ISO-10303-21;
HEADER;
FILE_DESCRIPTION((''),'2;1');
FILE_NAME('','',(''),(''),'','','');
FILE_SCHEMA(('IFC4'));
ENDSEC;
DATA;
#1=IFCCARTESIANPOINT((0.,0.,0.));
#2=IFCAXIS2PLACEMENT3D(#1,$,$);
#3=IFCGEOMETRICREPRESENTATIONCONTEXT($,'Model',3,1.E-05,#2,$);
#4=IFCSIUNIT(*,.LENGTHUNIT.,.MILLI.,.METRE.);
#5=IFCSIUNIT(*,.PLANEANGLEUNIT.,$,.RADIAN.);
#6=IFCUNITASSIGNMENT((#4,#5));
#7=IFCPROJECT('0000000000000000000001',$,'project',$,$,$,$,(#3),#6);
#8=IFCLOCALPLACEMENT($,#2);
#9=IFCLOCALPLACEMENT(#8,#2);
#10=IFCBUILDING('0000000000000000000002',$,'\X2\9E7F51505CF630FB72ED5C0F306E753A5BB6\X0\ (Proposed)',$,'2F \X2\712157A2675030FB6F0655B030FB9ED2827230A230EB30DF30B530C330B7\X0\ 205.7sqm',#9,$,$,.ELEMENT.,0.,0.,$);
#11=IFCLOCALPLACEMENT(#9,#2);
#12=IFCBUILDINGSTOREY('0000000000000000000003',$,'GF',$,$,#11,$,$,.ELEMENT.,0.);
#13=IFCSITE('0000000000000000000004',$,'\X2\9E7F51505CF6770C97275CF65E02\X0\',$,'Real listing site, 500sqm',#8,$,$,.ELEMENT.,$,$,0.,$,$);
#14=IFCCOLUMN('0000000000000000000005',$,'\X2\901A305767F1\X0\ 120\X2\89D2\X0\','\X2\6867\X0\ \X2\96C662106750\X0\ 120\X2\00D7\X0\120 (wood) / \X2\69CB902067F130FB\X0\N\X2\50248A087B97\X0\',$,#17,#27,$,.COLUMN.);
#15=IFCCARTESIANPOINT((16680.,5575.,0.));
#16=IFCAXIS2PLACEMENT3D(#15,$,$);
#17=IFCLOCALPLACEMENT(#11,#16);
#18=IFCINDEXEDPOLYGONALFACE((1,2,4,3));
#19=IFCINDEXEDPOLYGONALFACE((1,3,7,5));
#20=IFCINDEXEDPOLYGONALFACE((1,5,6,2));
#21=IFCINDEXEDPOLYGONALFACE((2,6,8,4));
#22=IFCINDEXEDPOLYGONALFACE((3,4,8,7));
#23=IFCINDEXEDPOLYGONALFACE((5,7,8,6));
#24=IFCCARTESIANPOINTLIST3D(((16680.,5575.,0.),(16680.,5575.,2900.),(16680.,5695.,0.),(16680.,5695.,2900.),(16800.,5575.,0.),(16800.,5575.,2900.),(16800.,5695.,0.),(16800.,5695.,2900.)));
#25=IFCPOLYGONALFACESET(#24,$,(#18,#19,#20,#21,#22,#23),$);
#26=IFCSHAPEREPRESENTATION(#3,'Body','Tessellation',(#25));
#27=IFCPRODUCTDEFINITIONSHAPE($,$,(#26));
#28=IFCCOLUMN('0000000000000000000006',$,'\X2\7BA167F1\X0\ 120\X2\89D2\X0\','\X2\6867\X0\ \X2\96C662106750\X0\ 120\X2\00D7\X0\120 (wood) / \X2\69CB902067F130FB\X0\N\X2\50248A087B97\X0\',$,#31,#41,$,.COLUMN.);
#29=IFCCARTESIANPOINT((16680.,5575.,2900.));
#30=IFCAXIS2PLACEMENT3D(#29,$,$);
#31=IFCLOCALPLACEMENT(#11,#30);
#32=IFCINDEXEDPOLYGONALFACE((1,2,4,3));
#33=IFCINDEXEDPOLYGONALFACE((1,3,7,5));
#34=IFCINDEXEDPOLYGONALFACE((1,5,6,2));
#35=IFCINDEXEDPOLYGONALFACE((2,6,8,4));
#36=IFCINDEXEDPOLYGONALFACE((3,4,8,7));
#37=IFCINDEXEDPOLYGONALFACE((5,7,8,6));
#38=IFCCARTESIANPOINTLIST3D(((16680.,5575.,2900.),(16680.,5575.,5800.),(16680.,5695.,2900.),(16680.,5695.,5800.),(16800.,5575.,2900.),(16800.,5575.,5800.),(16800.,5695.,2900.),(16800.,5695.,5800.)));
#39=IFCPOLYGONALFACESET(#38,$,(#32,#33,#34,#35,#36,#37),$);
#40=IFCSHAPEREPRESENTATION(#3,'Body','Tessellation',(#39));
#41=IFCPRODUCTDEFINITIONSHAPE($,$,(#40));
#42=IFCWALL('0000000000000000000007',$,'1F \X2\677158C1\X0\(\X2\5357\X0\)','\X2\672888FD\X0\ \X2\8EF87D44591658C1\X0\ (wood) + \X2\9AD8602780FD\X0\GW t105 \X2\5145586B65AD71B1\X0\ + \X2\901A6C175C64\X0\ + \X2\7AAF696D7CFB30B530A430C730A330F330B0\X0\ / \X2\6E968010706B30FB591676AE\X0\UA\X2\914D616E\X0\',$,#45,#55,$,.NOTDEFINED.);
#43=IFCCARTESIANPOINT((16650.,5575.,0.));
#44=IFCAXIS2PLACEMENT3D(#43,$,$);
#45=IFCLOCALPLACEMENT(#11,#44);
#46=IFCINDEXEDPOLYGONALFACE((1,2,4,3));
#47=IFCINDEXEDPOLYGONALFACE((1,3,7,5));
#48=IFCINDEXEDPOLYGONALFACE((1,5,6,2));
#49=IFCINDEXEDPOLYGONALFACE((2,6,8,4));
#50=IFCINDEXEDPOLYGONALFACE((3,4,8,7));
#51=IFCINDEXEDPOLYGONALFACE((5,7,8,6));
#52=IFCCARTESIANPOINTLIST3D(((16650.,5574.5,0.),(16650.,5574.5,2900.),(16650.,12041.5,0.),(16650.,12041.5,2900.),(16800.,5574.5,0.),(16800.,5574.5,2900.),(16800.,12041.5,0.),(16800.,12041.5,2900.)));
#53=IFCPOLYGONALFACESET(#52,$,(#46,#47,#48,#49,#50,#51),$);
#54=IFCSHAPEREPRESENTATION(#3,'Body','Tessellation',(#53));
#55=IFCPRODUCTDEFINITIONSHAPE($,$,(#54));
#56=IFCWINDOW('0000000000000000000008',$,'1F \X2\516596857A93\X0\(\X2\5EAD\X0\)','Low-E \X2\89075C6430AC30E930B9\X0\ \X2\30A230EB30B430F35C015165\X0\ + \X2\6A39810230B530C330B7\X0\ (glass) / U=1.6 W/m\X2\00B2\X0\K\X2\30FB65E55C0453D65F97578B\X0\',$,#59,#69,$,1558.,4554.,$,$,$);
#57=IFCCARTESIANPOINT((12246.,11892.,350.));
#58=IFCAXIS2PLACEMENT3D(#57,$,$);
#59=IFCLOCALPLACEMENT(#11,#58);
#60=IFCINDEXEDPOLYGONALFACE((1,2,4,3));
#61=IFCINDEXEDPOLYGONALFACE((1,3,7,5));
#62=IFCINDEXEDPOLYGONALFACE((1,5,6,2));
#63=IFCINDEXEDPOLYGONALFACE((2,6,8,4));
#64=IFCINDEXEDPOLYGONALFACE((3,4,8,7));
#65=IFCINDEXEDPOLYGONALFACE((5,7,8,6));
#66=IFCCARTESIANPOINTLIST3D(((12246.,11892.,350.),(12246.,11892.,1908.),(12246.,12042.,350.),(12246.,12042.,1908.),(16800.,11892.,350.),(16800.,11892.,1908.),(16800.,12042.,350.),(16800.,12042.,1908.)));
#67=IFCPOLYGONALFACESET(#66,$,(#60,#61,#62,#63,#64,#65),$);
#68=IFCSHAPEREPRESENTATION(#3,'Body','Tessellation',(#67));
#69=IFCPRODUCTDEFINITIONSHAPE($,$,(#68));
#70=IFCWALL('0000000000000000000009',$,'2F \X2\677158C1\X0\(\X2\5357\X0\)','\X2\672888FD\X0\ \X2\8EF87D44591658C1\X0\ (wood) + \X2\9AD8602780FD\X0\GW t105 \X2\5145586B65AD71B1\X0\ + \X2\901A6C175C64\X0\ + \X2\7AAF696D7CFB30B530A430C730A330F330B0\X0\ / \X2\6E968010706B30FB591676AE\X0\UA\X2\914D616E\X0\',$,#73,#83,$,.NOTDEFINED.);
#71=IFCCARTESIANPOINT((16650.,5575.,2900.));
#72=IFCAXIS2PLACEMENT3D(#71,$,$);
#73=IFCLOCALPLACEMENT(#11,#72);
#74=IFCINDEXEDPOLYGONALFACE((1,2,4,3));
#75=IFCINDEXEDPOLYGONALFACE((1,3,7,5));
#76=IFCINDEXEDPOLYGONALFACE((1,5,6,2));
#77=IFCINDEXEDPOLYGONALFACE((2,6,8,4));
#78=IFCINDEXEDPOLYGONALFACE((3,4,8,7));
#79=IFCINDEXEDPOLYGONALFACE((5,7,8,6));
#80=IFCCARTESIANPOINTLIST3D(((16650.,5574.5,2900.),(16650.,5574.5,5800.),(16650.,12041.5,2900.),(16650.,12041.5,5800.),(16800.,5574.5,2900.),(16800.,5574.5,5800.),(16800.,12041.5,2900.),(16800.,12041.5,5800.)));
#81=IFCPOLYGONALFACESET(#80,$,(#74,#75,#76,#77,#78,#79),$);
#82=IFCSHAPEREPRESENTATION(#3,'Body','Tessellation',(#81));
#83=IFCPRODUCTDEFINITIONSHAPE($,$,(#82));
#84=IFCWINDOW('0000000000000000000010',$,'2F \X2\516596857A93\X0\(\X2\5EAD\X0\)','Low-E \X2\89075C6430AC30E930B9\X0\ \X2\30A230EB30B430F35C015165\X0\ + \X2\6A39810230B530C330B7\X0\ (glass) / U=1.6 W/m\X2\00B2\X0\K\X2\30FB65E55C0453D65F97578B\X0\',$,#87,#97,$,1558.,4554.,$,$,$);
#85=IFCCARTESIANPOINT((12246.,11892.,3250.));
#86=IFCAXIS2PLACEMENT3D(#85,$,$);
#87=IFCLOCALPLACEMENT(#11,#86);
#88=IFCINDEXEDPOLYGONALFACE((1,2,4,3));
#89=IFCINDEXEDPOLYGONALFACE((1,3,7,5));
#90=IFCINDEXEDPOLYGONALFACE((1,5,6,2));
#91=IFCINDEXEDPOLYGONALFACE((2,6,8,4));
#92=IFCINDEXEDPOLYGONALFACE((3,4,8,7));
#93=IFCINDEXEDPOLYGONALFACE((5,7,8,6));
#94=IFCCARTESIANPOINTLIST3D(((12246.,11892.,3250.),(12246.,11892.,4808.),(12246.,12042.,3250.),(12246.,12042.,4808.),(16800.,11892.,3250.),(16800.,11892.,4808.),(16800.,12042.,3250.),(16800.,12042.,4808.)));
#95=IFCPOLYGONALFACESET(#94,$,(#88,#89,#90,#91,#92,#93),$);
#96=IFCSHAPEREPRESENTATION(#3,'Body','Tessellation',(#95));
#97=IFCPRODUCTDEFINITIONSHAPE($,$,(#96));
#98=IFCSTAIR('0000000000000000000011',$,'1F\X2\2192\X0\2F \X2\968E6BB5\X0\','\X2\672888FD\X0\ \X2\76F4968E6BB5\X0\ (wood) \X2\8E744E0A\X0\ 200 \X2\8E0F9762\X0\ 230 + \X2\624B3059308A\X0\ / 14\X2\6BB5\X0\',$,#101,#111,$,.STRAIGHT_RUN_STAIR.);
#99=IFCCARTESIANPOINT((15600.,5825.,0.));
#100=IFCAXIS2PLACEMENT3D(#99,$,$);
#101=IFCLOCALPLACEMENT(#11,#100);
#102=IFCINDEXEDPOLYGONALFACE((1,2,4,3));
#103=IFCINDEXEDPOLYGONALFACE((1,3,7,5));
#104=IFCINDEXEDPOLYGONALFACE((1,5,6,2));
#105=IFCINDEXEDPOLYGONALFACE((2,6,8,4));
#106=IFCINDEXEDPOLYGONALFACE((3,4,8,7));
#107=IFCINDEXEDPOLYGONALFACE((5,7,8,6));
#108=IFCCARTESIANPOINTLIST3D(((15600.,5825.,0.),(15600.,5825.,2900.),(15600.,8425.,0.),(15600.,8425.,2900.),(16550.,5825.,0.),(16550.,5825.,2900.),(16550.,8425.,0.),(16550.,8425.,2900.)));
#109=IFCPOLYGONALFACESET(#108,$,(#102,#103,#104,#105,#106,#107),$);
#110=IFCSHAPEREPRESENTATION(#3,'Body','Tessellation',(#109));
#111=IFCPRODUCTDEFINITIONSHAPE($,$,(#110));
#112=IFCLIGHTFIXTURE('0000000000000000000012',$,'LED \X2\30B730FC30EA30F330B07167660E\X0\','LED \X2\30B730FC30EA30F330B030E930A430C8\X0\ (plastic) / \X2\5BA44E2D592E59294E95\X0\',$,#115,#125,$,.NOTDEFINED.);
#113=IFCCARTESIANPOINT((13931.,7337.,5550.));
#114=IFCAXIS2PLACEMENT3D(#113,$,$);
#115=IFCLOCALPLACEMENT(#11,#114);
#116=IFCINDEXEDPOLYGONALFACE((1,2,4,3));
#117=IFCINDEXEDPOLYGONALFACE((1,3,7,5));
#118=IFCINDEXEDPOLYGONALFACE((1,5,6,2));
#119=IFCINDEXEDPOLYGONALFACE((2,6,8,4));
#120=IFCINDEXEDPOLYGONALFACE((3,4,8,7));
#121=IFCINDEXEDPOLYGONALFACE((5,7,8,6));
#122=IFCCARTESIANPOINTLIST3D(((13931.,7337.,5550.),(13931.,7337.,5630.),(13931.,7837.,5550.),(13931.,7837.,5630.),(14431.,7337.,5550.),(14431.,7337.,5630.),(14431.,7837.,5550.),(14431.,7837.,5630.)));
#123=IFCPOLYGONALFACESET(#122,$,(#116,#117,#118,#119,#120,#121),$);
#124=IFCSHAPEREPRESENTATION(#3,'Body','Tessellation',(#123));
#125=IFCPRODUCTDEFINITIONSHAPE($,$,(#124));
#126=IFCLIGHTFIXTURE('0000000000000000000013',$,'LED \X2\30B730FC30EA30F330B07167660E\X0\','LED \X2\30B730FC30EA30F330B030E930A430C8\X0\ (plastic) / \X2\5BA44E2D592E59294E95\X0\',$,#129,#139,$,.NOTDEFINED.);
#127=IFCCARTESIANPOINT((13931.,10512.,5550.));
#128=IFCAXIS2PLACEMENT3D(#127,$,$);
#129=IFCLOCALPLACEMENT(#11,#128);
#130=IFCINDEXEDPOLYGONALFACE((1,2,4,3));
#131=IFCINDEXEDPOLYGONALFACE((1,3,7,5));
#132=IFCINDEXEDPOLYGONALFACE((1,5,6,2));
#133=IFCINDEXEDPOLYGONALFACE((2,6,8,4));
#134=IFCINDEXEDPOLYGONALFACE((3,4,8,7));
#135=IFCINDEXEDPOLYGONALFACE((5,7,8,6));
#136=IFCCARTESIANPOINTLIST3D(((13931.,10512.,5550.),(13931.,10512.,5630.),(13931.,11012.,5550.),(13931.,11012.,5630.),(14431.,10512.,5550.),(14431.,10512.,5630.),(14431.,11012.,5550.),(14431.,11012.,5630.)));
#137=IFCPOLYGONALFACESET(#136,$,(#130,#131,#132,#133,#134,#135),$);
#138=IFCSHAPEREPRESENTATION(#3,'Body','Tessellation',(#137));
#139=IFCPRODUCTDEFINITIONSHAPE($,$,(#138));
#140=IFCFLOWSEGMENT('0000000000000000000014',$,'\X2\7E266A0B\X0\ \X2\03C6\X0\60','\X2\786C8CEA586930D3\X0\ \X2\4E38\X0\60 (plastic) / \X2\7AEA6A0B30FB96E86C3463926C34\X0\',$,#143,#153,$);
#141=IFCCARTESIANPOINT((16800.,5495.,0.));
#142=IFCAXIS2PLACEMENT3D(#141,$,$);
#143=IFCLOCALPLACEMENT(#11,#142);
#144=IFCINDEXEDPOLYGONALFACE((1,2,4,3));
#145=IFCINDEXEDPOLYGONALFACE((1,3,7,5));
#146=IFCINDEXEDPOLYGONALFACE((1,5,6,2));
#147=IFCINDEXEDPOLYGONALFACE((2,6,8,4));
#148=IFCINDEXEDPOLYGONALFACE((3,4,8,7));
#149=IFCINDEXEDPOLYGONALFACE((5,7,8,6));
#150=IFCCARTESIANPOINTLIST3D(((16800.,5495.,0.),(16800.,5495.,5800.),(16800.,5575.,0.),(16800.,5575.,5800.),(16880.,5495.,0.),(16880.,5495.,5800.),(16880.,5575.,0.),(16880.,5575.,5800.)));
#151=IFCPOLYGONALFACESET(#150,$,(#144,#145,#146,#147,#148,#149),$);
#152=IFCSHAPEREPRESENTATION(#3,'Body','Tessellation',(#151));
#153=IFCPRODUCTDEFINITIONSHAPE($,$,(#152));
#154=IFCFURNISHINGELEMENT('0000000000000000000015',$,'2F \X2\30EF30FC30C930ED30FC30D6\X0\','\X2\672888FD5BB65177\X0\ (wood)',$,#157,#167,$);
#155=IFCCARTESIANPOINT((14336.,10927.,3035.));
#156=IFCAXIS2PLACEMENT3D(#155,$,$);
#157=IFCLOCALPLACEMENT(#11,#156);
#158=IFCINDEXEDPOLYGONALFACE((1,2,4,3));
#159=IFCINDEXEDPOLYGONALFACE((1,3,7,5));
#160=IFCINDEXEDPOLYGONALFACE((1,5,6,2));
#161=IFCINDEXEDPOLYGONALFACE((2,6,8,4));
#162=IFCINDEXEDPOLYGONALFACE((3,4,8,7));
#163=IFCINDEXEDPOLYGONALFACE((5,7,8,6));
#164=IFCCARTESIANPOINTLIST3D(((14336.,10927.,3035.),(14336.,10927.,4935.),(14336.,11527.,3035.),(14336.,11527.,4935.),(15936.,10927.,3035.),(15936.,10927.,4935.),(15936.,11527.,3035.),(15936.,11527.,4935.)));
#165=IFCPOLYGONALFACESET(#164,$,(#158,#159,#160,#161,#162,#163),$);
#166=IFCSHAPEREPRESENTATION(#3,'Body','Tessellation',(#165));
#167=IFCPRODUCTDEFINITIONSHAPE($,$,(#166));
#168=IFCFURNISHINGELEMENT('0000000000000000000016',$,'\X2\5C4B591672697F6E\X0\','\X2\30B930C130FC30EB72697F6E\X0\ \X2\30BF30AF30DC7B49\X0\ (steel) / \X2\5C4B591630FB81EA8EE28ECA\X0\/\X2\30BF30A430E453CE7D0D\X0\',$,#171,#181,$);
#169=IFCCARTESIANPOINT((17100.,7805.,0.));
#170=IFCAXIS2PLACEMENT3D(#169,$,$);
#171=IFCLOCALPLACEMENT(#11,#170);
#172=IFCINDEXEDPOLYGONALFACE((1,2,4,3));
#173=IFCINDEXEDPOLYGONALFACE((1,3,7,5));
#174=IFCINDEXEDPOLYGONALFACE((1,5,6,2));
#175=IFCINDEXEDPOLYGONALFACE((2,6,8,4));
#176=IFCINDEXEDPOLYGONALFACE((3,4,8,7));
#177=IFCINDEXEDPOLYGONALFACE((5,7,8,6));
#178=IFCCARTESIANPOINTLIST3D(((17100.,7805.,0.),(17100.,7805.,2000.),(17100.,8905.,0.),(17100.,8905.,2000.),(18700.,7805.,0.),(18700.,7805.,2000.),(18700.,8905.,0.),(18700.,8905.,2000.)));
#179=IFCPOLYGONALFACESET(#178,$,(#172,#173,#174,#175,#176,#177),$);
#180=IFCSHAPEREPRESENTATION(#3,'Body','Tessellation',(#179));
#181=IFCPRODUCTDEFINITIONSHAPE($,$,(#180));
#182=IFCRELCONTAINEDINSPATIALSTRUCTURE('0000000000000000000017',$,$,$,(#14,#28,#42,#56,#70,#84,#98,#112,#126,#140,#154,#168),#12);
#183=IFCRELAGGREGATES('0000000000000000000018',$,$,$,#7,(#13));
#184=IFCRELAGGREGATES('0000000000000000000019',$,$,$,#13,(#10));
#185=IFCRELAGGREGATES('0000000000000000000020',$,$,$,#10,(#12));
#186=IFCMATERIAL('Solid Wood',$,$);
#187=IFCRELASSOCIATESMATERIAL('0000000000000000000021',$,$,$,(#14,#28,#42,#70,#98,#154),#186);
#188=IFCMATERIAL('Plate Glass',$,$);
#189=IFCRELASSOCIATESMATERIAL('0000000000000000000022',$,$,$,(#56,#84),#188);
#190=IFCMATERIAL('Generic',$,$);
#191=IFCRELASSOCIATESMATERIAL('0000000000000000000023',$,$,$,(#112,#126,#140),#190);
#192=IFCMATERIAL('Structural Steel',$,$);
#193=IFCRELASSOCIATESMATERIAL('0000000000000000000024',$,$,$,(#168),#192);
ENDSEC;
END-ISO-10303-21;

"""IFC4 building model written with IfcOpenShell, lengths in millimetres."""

from ifc_helpers import new_model, si_unit, frame, frame_2d, origin, place, context, project, spatial, rectangle, extrude, material, element, fill, save


model = new_model("IFC4")

# Units and contexts
model_context = context("Model", 3, precision=1e-05, world=origin())
ifc_project = project(units=[si_unit("LENGTHUNIT", "METRE", prefix="MILLI"), si_unit("PLANEANGLEUNIT", "RADIAN")], contexts=[model_context])

# Site, building, storey
site_placement = place(None, origin())
site = spatial("IfcSite", under=ifc_project, at=site_placement, Name="鹿児島県霧島市", ObjectType="Real listing site, 500sqm", CompositionType="ELEMENT", RefElevation=0.0)
building_placement = place(site_placement, origin())
building = spatial("IfcBuilding", under=site, at=building_placement, Name="鹿児島・狭小の町家 (Proposed)", ObjectType="2F 無垢材・漆喰・黒色アルミサッシ 205.7sqm", CompositionType="ELEMENT", ElevationOfRefHeight=0.0, ElevationOfTerrain=0.0)
storey_placement = place(building_placement, origin())
storey = spatial("IfcBuildingStorey", under=building, at=storey_placement, Name="GF", CompositionType="ELEMENT", Elevation=0.0)

# Columns
ifc_material_1 = material(Name="Solid Wood")
column_1_placement = place(storey_placement, frame((16680.0, 5575.0, 0.0)))
element("IfcColumn", 1, at=column_1_placement, inside=storey, material=ifc_material_1, Name="通し柱 120角", Description="桧 集成材 120×120 (wood) / 構造柱・N値計算", PredefinedType="COLUMN", context=model_context, shape_type="SweptSolid", body=[
    extrude(rectangle(XDim=120.0, YDim=120.0, at=frame_2d((60.0, 60.0))), frame((16680.0, 5575.0, 0.0)), (0.0, 0.0, 1.0), 2900.0),
])
column_2_placement = place(storey_placement, frame((16680.0, 5575.0, 2900.0)))
element("IfcColumn", 2, at=column_2_placement, inside=storey, material=ifc_material_1, Name="管柱 120角", Description="桧 集成材 120×120 (wood) / 構造柱・N値計算", PredefinedType="COLUMN", context=model_context, shape_type="SweptSolid", body=[
    extrude(rectangle(XDim=120.0, YDim=120.0, at=frame_2d((60.0, 60.0))), frame((16680.0, 5575.0, 2900.0)), (0.0, 0.0, 1.0), 2900.0),
])

# Wall, opening, window
wall_1_placement = place(storey_placement, frame((16650.0, 5575.0, 0.0)))
wall_1 = element("IfcWall", 3, at=wall_1_placement, inside=storey, material=ifc_material_1, Name="1F 東壁(南)", Description="木製 軸組外壁 (wood) + 高性能GW t105 充填断熱 + 通気層 + 窯業系サイディング / 準耐火・外皮UA配慮", PredefinedType="NOTDEFINED", context=model_context, shape_type="SweptSolid", body=[
    extrude(rectangle(XDim=150.0, YDim=6467.0, at=frame_2d((75.0, 3233.0))), frame((16650.0, 5575.0, 0.0)), (0.0, 0.0, 1.0), 2900.0),
])
opening_1_placement = place(storey_placement, frame((12246.0, 11892.0, 350.0)))
opening_1 = element("IfcOpeningElement", 4, at=opening_1_placement, cuts=wall_1, PredefinedType="NOTDEFINED", context=model_context, shape_type="SweptSolid", body=[
    extrude(rectangle(XDim=4554.0, YDim=150.0, at=frame_2d((2277.0, 75.0))), frame((12246.0, 11892.0, 350.0)), (0.0, 0.0, 1.0), 1558.0),
])
ifc_material_2 = material(Name="Plate Glass")
window_1_placement = place(storey_placement, frame((12246.0, 11892.0, 350.0)))
window_1 = element("IfcWindow", 5, at=window_1_placement, inside=storey, material=ifc_material_2, Name="1F 入隅窓(庭)", Description="Low-E 複層ガラス アルゴン封入 + 樹脂サッシ (glass) / U=1.6 W/m²K・日射取得型", OverallHeight=1558.0, OverallWidth=4554.0, context=model_context, shape_type="SweptSolid", body=[
    extrude(rectangle(XDim=4554.0, YDim=150.0, at=frame_2d((2277.0, 75.0))), frame((12246.0, 11892.0, 350.0)), (0.0, 0.0, 1.0), 1558.0),
])
fill(opening_1, window_1)

# Wall, opening, window
wall_2_placement = place(storey_placement, frame((16650.0, 5575.0, 2900.0)))
wall_2 = element("IfcWall", 6, at=wall_2_placement, inside=storey, material=ifc_material_1, Name="2F 東壁(南)", Description="木製 軸組外壁 (wood) + 高性能GW t105 充填断熱 + 通気層 + 窯業系サイディング / 準耐火・外皮UA配慮", PredefinedType="NOTDEFINED", context=model_context, shape_type="SweptSolid", body=[
    extrude(rectangle(XDim=150.0, YDim=6467.0, at=frame_2d((75.0, 3233.0))), frame((16650.0, 5575.0, 2900.0)), (0.0, 0.0, 1.0), 2900.0),
])
opening_2_placement = place(storey_placement, frame((12246.0, 11892.0, 3250.0)))
opening_2 = element("IfcOpeningElement", 7, at=opening_2_placement, cuts=wall_2, PredefinedType="NOTDEFINED", context=model_context, shape_type="SweptSolid", body=[
    extrude(rectangle(XDim=4554.0, YDim=150.0, at=frame_2d((2277.0, 75.0))), frame((12246.0, 11892.0, 3250.0)), (0.0, 0.0, 1.0), 1558.0),
])
window_2_placement = place(storey_placement, frame((12246.0, 11892.0, 3250.0)))
window_2 = element("IfcWindow", 8, at=window_2_placement, inside=storey, material=ifc_material_2, Name="2F 入隅窓(庭)", Description="Low-E 複層ガラス アルゴン封入 + 樹脂サッシ (glass) / U=1.6 W/m²K・日射取得型", OverallHeight=1558.0, OverallWidth=4554.0, context=model_context, shape_type="SweptSolid", body=[
    extrude(rectangle(XDim=4554.0, YDim=150.0, at=frame_2d((2277.0, 75.0))), frame((12246.0, 11892.0, 3250.0)), (0.0, 0.0, 1.0), 1558.0),
])
fill(opening_2, window_2)

# Stair
stair_placement = place(storey_placement, frame((15600.0, 5825.0, 0.0)))
element("IfcStair", 9, at=stair_placement, inside=storey, material=ifc_material_1, Name="1F→2F 階段", Description="木製 直階段 (wood) 蹴上 200 踏面 230 + 手すり / 14段", PredefinedType="STRAIGHT_RUN_STAIR", context=model_context, shape_type="SweptSolid", body=[
    extrude(rectangle(XDim=950.0, YDim=2600.0, at=frame_2d((475.0, 1300.0))), frame((15600.0, 5825.0, 0.0)), (0.0, 0.0, 1.0), 2900.0),
])

# Light fixtures
ifc_material_3 = material(Name="Generic")
light_fixture_1_placement = place(storey_placement, frame((13931.0, 7337.0, 5550.0)))
element("IfcLightFixture", 10, at=light_fixture_1_placement, inside=storey, material=ifc_material_3, Name="LED シーリング照明", Description="LED シーリングライト (plastic) / 室中央天井", PredefinedType="NOTDEFINED", context=model_context, shape_type="SweptSolid", body=[
    extrude(rectangle(XDim=500.0, YDim=500.0, at=frame_2d((250.0, 250.0))), frame((13931.0, 7337.0, 5550.0)), (0.0, 0.0, 1.0), 80.0),
])
light_fixture_2_placement = place(storey_placement, frame((13931.0, 10512.0, 5550.0)))
element("IfcLightFixture", 11, at=light_fixture_2_placement, inside=storey, material=ifc_material_3, Name="LED シーリング照明", Description="LED シーリングライト (plastic) / 室中央天井", PredefinedType="NOTDEFINED", context=model_context, shape_type="SweptSolid", body=[
    extrude(rectangle(XDim=500.0, YDim=500.0, at=frame_2d((250.0, 250.0))), frame((13931.0, 10512.0, 5550.0)), (0.0, 0.0, 1.0), 80.0),
])

# Flow segment
flow_segment_placement = place(storey_placement, frame((16800.0, 5495.0, 0.0)))
element("IfcFlowSegment", 12, at=flow_segment_placement, inside=storey, material=ifc_material_3, Name="縦樋 φ60", Description="硬質塩ビ 丸60 (plastic) / 竪樋・雨水排水", context=model_context, shape_type="SweptSolid", body=[
    extrude(rectangle(XDim=80.0, YDim=80.0, at=frame_2d((40.0, 40.0))), frame((16800.0, 5495.0, 0.0)), (0.0, 0.0, 1.0), 5800.0),
])

# Furnishing elements
furnishing_1_placement = place(storey_placement, frame((14336.0, 10927.0, 3035.0)))
element("IfcFurnishingElement", 13, at=furnishing_1_placement, inside=storey, material=ifc_material_1, Name="2F ワードローブ", Description="木製家具 (wood)", context=model_context, shape_type="SweptSolid", body=[
    extrude(rectangle(XDim=1600.0, YDim=600.0, at=frame_2d((800.0, 300.0))), frame((14336.0, 10927.0, 3035.0)), (0.0, 0.0, 1.0), 1900.0),
])
ifc_material_4 = material(Name="Structural Steel")
furnishing_2_placement = place(storey_placement, frame((17100.0, 7805.0, 0.0)))
element("IfcFurnishingElement", 14, at=furnishing_2_placement, inside=storey, material=ifc_material_4, Name="屋外物置", Description="スチール物置 タクボ等 (steel) / 屋外・自転車/タイヤ収納", context=model_context, shape_type="SweptSolid", body=[
    extrude(rectangle(XDim=1600.0, YDim=1100.0, at=frame_2d((800.0, 550.0))), frame((17100.0, 7805.0, 0.0)), (0.0, 0.0, 1.0), 2000.0),
])

save(model, "model.ifc")
